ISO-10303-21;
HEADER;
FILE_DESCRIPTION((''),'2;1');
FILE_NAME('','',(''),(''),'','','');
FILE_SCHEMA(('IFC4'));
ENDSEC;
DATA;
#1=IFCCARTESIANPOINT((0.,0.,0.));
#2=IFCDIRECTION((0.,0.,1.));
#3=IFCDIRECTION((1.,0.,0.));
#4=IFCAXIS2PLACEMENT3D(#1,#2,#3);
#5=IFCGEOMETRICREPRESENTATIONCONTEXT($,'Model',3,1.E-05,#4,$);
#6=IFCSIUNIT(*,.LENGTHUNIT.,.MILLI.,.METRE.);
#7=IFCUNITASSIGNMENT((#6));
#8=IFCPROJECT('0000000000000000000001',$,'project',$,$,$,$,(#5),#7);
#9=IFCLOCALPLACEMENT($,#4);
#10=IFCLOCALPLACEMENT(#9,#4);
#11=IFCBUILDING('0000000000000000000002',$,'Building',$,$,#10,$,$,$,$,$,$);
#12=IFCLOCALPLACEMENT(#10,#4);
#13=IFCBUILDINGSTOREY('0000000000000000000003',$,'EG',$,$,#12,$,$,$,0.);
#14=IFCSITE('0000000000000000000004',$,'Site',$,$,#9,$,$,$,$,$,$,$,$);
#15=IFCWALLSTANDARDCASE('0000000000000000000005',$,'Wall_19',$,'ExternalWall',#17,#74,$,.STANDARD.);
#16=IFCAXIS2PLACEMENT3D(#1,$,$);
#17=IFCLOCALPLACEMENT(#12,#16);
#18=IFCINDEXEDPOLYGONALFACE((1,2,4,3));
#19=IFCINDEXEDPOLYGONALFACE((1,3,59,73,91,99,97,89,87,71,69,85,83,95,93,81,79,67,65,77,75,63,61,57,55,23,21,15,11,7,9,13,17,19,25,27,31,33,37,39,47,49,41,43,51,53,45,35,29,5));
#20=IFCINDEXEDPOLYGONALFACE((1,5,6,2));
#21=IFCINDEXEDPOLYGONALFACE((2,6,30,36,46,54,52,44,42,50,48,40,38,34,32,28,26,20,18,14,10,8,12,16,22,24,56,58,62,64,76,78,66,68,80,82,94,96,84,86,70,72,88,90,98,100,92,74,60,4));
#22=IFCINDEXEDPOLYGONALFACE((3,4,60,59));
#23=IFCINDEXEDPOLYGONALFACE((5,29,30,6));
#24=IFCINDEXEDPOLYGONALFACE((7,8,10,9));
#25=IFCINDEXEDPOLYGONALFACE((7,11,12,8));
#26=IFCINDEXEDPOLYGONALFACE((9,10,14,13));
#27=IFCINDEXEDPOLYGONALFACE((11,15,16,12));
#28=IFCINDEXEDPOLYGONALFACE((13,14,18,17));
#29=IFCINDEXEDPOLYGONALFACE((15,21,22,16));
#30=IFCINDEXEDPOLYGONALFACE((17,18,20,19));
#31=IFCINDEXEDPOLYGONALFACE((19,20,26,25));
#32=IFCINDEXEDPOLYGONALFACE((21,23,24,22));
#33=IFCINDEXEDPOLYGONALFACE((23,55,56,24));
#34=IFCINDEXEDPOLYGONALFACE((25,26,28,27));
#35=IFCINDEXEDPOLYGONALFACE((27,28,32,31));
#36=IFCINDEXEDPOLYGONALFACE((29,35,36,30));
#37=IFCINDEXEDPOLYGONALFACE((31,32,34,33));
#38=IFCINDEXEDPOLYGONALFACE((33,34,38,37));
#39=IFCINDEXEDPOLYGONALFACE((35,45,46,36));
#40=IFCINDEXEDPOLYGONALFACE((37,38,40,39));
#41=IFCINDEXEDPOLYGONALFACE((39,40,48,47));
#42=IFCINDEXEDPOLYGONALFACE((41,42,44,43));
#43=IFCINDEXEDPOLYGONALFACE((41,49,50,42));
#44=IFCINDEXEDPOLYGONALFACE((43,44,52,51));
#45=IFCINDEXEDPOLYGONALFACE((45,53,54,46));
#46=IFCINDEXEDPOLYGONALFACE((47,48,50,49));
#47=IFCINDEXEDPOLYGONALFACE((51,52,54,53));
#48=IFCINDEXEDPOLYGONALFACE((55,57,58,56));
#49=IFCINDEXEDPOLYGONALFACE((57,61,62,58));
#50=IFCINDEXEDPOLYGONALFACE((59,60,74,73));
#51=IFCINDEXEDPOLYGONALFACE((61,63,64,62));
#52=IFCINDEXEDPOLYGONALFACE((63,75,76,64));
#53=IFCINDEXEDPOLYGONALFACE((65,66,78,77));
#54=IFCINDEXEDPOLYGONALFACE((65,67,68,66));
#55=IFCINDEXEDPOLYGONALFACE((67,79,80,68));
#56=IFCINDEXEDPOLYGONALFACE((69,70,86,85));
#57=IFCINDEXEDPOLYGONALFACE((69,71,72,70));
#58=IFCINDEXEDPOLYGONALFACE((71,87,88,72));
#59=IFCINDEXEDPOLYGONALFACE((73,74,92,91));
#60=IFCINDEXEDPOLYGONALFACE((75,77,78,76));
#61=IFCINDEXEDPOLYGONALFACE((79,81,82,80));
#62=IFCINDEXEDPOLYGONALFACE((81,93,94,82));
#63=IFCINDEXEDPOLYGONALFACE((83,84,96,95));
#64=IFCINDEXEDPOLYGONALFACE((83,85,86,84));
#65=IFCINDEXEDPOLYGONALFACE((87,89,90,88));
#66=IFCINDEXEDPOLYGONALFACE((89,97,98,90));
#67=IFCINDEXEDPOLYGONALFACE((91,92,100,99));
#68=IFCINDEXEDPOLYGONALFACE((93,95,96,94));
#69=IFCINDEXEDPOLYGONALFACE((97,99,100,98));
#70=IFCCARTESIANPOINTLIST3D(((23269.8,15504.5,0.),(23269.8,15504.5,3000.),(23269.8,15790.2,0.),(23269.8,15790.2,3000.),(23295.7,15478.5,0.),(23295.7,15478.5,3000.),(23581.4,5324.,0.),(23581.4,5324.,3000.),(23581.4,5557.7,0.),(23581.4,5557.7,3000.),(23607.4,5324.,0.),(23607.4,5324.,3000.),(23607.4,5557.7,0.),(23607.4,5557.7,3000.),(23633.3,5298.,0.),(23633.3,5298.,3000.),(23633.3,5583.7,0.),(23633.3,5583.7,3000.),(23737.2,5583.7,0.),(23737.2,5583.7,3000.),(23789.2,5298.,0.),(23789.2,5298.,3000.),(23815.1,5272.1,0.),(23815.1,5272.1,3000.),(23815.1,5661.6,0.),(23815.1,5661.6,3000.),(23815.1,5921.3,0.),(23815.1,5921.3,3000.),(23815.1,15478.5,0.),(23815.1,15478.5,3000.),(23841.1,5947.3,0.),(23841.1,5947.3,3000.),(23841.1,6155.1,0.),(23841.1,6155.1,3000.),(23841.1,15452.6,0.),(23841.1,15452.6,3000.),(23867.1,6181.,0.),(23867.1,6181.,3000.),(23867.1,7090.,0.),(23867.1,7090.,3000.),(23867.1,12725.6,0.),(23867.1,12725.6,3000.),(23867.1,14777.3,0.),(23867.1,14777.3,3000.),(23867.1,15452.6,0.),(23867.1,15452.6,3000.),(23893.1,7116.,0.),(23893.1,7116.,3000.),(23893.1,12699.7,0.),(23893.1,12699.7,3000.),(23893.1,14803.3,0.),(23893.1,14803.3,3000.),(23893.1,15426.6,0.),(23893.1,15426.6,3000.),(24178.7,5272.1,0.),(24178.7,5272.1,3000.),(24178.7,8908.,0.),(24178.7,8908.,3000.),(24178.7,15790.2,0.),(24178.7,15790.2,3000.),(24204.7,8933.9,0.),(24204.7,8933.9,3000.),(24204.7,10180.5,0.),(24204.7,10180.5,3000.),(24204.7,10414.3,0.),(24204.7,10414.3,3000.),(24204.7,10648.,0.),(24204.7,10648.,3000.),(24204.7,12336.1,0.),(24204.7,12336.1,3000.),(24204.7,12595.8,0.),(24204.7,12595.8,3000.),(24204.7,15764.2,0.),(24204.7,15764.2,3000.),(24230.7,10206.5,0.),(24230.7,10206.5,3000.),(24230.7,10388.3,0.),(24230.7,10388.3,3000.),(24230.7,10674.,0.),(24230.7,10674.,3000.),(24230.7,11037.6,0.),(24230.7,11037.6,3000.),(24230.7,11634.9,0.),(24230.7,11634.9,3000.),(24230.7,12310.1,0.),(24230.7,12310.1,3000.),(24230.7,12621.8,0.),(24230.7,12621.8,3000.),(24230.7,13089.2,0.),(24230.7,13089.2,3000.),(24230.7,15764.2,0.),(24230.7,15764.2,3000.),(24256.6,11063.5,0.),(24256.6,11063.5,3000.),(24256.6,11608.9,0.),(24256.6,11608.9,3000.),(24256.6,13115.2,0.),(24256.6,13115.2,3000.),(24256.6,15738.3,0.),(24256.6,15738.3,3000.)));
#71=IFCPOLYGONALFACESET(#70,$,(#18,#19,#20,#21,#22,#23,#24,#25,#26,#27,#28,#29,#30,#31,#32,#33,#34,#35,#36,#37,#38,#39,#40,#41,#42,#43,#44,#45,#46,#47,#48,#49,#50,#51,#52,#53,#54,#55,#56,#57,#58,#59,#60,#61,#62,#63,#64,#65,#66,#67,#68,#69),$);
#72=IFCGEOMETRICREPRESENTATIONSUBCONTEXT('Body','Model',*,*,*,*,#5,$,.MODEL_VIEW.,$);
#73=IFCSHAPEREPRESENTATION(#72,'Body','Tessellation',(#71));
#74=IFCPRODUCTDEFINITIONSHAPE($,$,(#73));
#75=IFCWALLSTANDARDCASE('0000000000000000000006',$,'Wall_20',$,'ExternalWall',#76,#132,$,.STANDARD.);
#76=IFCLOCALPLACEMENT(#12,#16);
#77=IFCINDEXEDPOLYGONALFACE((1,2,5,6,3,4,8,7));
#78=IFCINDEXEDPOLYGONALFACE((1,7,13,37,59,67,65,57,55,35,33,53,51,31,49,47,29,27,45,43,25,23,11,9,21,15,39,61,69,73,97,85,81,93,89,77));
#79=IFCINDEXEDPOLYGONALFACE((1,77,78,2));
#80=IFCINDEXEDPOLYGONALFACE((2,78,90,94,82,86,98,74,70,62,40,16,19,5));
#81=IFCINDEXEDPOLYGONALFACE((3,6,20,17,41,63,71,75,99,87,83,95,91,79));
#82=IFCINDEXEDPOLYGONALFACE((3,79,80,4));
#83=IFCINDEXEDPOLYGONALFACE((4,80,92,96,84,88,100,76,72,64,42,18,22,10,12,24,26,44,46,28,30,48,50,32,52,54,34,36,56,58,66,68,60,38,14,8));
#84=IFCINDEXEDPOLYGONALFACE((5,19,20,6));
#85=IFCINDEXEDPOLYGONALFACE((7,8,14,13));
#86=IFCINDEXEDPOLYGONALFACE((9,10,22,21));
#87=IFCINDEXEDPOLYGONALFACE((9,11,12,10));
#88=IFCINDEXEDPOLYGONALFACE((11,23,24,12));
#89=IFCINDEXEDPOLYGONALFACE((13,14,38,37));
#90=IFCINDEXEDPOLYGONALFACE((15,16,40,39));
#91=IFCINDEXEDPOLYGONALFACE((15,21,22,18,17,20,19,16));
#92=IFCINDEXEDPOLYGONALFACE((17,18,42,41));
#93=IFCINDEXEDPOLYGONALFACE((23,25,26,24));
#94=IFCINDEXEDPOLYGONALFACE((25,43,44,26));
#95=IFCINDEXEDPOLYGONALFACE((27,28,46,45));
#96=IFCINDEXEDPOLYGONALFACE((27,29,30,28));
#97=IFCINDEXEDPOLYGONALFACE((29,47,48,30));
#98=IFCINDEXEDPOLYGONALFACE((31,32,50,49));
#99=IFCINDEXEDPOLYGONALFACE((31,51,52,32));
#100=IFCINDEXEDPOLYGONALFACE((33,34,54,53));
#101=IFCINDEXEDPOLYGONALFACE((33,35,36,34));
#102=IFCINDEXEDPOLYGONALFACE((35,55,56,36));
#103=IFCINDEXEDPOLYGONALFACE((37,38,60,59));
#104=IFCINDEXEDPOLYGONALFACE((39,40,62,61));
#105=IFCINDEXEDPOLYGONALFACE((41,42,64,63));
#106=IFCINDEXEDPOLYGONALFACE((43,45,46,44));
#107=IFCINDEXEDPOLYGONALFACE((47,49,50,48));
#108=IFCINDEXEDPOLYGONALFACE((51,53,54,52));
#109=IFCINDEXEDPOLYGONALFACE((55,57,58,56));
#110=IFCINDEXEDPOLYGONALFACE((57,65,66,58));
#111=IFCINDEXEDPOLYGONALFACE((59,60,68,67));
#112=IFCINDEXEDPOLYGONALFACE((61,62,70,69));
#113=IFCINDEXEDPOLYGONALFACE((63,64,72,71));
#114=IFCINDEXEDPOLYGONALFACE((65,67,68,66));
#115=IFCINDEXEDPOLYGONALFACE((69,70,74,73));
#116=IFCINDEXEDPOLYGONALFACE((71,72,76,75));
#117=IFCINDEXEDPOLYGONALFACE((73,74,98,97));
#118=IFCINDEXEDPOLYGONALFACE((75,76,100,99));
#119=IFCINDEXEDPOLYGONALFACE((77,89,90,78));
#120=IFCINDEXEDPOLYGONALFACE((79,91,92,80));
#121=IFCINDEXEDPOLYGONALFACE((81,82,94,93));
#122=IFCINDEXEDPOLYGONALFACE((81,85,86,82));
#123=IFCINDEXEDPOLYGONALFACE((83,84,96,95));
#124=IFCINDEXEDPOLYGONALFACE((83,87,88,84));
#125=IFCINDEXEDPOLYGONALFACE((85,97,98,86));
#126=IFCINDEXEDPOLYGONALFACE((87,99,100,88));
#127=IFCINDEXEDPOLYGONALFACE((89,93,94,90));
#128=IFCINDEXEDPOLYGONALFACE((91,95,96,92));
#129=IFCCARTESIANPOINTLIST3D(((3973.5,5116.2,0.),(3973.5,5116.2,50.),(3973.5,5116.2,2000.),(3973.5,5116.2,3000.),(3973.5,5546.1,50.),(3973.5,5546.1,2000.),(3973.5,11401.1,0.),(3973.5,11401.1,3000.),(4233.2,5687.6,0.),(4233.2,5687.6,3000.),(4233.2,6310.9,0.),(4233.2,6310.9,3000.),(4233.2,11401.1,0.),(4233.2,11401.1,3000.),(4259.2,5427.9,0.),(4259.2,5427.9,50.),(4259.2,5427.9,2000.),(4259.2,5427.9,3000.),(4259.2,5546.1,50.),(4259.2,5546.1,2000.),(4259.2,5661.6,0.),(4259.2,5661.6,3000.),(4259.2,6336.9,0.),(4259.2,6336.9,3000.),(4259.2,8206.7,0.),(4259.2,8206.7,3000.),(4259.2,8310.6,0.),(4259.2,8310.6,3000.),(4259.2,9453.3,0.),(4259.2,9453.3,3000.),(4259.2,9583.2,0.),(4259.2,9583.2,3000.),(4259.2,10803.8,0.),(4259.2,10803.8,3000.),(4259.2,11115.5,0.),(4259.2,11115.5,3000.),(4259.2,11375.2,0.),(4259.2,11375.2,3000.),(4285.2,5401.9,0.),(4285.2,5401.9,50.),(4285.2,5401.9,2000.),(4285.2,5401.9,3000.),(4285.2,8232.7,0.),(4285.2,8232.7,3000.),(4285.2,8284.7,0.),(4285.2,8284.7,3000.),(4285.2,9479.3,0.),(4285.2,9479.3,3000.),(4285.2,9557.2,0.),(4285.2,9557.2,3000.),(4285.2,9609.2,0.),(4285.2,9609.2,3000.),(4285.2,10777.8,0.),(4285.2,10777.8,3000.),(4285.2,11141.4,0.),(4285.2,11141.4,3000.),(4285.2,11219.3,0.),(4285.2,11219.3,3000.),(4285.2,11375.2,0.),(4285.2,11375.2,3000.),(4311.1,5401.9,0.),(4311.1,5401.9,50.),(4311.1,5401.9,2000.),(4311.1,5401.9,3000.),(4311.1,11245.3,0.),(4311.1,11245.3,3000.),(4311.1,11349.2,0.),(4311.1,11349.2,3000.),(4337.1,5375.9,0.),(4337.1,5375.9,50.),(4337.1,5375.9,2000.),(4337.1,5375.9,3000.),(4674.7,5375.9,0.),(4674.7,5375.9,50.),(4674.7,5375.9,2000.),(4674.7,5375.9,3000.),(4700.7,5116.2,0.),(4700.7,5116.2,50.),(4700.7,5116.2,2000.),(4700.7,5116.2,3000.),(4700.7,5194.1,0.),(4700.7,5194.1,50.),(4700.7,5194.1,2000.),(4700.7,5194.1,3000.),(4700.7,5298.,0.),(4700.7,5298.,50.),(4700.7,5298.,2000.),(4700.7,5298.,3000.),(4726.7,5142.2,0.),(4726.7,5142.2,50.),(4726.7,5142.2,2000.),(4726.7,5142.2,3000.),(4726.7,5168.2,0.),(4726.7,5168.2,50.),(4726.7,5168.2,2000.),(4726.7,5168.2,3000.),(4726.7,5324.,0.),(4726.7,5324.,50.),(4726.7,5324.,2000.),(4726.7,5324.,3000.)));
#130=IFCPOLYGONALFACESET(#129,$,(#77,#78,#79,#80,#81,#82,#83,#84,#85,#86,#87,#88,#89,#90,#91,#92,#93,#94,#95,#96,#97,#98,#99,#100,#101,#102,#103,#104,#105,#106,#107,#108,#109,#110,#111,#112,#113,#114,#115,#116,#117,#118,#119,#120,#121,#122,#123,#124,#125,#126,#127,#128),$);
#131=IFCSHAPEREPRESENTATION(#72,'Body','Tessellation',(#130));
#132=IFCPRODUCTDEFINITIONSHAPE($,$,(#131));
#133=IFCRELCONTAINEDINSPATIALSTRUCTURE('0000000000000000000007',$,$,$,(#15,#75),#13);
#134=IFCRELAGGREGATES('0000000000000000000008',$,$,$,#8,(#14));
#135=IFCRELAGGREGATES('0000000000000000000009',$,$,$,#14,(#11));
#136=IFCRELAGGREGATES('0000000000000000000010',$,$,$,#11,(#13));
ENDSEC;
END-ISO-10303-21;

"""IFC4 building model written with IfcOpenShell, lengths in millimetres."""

from ifc_helpers import new_model, si_unit, frame, origin_with_axes, place, context, subcontext, project, spatial, polyline, rectangle, outline, extrude, element, save


model = new_model("IFC4")

# Units and contexts
model_context = context("Model", 3, precision=1e-05, world=origin_with_axes())
body_context = subcontext(model_context, "Body", "Model", "MODEL_VIEW")
ifc_project = project(units=[si_unit("LENGTHUNIT", "METRE", prefix="MILLI")], contexts=[model_context])

# Site, building, storey
site_placement = place(None, origin_with_axes())
site = spatial("IfcSite", under=ifc_project, at=site_placement, Name="Site")
building_placement = place(site_placement, origin_with_axes())
building = spatial("IfcBuilding", under=site, at=building_placement, Name="Building")
storey_placement = place(building_placement, origin_with_axes())
storey = spatial("IfcBuildingStorey", under=building, at=storey_placement, Name="EG", Elevation=0.0)

# Wall
wall_1_placement = place(storey_placement, origin_with_axes())
element("IfcWallStandardCase", 1, at=wall_1_placement, inside=storey, Name="Wall_19", ObjectType="ExternalWall", PredefinedType="STANDARD", context=body_context, shape_type="SweptSolid", body=[
    extrude(outline(polyline([(23815.1, 5272.1, 0.0), (23789.2, 5298.0, 0.0), (23633.3, 5298.0, 0.0), (23607.4, 5324.0, 0.0), (23581.4, 5324.0, 0.0), (23581.4, 5557.7, 0.0), (23607.4, 5557.7, 0.0), (23633.3, 5583.7, 0.0), (23737.2, 5583.7, 0.0), (23815.1, 5661.6, 0.0), (23815.1, 5921.3, 0.0), (23841.1, 5947.3, 0.0), (23841.1, 6155.1, 0.0), (23867.1, 6181.0, 0.0), (23867.1, 7090.0, 0.0), (23893.1, 7116.0, 0.0), (23893.1, 12699.7, 0.0), (23867.1, 12725.6, 0.0), (23867.1, 14777.3, 0.0), (23893.1, 14803.3, 0.0), (23893.1, 15426.6, 0.0), (23867.1, 15452.6, 0.0), (23841.1, 15452.6, 0.0), (23815.1, 15478.5, 0.0), (23295.7, 15478.5, 0.0), (23269.8, 15504.5, 0.0), (23269.8, 15790.2, 0.0), (24178.7, 15790.2, 0.0), (24204.7, 15764.2, 0.0), (24230.7, 15764.2, 0.0), (24256.6, 15738.3, 0.0), (24256.6, 13115.2, 0.0), (24230.7, 13089.2, 0.0), (24230.7, 12621.8, 0.0), (24204.7, 12595.8, 0.0), (24204.7, 12336.1, 0.0), (24230.7, 12310.1, 0.0), (24230.7, 11634.9, 0.0), (24256.6, 11608.9, 0.0), (24256.6, 11063.5, 0.0), (24230.7, 11037.6, 0.0), (24230.7, 10674.0, 0.0), (24204.7, 10648.0, 0.0), (24204.7, 10414.3, 0.0), (24230.7, 10388.3, 0.0), (24230.7, 10206.5, 0.0), (24204.7, 10180.5, 0.0), (24204.7, 8933.9, 0.0), (24178.7, 8908.0, 0.0), (24178.7, 5272.1, 0.0), (23815.1, 5272.1, 0.0)])), origin_with_axes(), (0.0, 0.0, 1.0), 3000.0),
])

# Wall, opening
wall_2_placement = place(storey_placement, origin_with_axes())
wall_2 = element("IfcWallStandardCase", 2, at=wall_2_placement, inside=storey, Name="Wall_20", ObjectType="ExternalWall", PredefinedType="STANDARD", context=body_context, shape_type="SweptSolid", body=[
    extrude(outline(polyline([(3973.5, 5116.2, 0.0), (3973.5, 11401.1, 0.0), (4233.2, 11401.1, 0.0), (4259.2, 11375.2, 0.0), (4285.2, 11375.2, 0.0), (4311.1, 11349.2, 0.0), (4311.1, 11245.3, 0.0), (4285.2, 11219.3, 0.0), (4285.2, 11141.4, 0.0), (4259.2, 11115.5, 0.0), (4259.2, 10803.8, 0.0), (4285.2, 10777.8, 0.0), (4285.2, 9609.2, 0.0), (4259.2, 9583.2, 0.0), (4285.2, 9557.2, 0.0), (4285.2, 9479.3, 0.0), (4259.2, 9453.3, 0.0), (4259.2, 8310.6, 0.0), (4285.2, 8284.7, 0.0), (4285.2, 8232.7, 0.0), (4259.2, 8206.7, 0.0), (4259.2, 6336.9, 0.0), (4233.2, 6310.9, 0.0), (4233.2, 5687.6, 0.0), (4259.2, 5661.6, 0.0), (4259.2, 5427.9, 0.0), (4285.2, 5401.9, 0.0), (4311.1, 5401.9, 0.0), (4337.1, 5375.9, 0.0), (4674.7, 5375.9, 0.0), (4726.7, 5324.0, 0.0), (4700.7, 5298.0, 0.0), (4700.7, 5194.1, 0.0), (4726.7, 5168.2, 0.0), (4726.7, 5142.2, 0.0), (4700.7, 5116.2, 0.0), (3973.5, 5116.2, 0.0)])), origin_with_axes(), (0.0, 0.0, 1.0), 3000.0),
])
opening_1_placement = place(wall_2_placement, origin_with_axes())
element("IfcOpeningElement", 3, at=opening_1_placement, inside=storey, cuts=wall_2, context=body_context, shape_type="SweptSolid", body=[
    extrude(rectangle(XDim=600.0, YDim=753.2), frame((4350.1, 5246.1, 50.0), z_axis=(0.0, 0.0, 1.0), x_axis=(0.0, 1.0, 0.0)), (0.0, 0.0, 1.0), 1950.0),
])

save(model, "model.ifc")
